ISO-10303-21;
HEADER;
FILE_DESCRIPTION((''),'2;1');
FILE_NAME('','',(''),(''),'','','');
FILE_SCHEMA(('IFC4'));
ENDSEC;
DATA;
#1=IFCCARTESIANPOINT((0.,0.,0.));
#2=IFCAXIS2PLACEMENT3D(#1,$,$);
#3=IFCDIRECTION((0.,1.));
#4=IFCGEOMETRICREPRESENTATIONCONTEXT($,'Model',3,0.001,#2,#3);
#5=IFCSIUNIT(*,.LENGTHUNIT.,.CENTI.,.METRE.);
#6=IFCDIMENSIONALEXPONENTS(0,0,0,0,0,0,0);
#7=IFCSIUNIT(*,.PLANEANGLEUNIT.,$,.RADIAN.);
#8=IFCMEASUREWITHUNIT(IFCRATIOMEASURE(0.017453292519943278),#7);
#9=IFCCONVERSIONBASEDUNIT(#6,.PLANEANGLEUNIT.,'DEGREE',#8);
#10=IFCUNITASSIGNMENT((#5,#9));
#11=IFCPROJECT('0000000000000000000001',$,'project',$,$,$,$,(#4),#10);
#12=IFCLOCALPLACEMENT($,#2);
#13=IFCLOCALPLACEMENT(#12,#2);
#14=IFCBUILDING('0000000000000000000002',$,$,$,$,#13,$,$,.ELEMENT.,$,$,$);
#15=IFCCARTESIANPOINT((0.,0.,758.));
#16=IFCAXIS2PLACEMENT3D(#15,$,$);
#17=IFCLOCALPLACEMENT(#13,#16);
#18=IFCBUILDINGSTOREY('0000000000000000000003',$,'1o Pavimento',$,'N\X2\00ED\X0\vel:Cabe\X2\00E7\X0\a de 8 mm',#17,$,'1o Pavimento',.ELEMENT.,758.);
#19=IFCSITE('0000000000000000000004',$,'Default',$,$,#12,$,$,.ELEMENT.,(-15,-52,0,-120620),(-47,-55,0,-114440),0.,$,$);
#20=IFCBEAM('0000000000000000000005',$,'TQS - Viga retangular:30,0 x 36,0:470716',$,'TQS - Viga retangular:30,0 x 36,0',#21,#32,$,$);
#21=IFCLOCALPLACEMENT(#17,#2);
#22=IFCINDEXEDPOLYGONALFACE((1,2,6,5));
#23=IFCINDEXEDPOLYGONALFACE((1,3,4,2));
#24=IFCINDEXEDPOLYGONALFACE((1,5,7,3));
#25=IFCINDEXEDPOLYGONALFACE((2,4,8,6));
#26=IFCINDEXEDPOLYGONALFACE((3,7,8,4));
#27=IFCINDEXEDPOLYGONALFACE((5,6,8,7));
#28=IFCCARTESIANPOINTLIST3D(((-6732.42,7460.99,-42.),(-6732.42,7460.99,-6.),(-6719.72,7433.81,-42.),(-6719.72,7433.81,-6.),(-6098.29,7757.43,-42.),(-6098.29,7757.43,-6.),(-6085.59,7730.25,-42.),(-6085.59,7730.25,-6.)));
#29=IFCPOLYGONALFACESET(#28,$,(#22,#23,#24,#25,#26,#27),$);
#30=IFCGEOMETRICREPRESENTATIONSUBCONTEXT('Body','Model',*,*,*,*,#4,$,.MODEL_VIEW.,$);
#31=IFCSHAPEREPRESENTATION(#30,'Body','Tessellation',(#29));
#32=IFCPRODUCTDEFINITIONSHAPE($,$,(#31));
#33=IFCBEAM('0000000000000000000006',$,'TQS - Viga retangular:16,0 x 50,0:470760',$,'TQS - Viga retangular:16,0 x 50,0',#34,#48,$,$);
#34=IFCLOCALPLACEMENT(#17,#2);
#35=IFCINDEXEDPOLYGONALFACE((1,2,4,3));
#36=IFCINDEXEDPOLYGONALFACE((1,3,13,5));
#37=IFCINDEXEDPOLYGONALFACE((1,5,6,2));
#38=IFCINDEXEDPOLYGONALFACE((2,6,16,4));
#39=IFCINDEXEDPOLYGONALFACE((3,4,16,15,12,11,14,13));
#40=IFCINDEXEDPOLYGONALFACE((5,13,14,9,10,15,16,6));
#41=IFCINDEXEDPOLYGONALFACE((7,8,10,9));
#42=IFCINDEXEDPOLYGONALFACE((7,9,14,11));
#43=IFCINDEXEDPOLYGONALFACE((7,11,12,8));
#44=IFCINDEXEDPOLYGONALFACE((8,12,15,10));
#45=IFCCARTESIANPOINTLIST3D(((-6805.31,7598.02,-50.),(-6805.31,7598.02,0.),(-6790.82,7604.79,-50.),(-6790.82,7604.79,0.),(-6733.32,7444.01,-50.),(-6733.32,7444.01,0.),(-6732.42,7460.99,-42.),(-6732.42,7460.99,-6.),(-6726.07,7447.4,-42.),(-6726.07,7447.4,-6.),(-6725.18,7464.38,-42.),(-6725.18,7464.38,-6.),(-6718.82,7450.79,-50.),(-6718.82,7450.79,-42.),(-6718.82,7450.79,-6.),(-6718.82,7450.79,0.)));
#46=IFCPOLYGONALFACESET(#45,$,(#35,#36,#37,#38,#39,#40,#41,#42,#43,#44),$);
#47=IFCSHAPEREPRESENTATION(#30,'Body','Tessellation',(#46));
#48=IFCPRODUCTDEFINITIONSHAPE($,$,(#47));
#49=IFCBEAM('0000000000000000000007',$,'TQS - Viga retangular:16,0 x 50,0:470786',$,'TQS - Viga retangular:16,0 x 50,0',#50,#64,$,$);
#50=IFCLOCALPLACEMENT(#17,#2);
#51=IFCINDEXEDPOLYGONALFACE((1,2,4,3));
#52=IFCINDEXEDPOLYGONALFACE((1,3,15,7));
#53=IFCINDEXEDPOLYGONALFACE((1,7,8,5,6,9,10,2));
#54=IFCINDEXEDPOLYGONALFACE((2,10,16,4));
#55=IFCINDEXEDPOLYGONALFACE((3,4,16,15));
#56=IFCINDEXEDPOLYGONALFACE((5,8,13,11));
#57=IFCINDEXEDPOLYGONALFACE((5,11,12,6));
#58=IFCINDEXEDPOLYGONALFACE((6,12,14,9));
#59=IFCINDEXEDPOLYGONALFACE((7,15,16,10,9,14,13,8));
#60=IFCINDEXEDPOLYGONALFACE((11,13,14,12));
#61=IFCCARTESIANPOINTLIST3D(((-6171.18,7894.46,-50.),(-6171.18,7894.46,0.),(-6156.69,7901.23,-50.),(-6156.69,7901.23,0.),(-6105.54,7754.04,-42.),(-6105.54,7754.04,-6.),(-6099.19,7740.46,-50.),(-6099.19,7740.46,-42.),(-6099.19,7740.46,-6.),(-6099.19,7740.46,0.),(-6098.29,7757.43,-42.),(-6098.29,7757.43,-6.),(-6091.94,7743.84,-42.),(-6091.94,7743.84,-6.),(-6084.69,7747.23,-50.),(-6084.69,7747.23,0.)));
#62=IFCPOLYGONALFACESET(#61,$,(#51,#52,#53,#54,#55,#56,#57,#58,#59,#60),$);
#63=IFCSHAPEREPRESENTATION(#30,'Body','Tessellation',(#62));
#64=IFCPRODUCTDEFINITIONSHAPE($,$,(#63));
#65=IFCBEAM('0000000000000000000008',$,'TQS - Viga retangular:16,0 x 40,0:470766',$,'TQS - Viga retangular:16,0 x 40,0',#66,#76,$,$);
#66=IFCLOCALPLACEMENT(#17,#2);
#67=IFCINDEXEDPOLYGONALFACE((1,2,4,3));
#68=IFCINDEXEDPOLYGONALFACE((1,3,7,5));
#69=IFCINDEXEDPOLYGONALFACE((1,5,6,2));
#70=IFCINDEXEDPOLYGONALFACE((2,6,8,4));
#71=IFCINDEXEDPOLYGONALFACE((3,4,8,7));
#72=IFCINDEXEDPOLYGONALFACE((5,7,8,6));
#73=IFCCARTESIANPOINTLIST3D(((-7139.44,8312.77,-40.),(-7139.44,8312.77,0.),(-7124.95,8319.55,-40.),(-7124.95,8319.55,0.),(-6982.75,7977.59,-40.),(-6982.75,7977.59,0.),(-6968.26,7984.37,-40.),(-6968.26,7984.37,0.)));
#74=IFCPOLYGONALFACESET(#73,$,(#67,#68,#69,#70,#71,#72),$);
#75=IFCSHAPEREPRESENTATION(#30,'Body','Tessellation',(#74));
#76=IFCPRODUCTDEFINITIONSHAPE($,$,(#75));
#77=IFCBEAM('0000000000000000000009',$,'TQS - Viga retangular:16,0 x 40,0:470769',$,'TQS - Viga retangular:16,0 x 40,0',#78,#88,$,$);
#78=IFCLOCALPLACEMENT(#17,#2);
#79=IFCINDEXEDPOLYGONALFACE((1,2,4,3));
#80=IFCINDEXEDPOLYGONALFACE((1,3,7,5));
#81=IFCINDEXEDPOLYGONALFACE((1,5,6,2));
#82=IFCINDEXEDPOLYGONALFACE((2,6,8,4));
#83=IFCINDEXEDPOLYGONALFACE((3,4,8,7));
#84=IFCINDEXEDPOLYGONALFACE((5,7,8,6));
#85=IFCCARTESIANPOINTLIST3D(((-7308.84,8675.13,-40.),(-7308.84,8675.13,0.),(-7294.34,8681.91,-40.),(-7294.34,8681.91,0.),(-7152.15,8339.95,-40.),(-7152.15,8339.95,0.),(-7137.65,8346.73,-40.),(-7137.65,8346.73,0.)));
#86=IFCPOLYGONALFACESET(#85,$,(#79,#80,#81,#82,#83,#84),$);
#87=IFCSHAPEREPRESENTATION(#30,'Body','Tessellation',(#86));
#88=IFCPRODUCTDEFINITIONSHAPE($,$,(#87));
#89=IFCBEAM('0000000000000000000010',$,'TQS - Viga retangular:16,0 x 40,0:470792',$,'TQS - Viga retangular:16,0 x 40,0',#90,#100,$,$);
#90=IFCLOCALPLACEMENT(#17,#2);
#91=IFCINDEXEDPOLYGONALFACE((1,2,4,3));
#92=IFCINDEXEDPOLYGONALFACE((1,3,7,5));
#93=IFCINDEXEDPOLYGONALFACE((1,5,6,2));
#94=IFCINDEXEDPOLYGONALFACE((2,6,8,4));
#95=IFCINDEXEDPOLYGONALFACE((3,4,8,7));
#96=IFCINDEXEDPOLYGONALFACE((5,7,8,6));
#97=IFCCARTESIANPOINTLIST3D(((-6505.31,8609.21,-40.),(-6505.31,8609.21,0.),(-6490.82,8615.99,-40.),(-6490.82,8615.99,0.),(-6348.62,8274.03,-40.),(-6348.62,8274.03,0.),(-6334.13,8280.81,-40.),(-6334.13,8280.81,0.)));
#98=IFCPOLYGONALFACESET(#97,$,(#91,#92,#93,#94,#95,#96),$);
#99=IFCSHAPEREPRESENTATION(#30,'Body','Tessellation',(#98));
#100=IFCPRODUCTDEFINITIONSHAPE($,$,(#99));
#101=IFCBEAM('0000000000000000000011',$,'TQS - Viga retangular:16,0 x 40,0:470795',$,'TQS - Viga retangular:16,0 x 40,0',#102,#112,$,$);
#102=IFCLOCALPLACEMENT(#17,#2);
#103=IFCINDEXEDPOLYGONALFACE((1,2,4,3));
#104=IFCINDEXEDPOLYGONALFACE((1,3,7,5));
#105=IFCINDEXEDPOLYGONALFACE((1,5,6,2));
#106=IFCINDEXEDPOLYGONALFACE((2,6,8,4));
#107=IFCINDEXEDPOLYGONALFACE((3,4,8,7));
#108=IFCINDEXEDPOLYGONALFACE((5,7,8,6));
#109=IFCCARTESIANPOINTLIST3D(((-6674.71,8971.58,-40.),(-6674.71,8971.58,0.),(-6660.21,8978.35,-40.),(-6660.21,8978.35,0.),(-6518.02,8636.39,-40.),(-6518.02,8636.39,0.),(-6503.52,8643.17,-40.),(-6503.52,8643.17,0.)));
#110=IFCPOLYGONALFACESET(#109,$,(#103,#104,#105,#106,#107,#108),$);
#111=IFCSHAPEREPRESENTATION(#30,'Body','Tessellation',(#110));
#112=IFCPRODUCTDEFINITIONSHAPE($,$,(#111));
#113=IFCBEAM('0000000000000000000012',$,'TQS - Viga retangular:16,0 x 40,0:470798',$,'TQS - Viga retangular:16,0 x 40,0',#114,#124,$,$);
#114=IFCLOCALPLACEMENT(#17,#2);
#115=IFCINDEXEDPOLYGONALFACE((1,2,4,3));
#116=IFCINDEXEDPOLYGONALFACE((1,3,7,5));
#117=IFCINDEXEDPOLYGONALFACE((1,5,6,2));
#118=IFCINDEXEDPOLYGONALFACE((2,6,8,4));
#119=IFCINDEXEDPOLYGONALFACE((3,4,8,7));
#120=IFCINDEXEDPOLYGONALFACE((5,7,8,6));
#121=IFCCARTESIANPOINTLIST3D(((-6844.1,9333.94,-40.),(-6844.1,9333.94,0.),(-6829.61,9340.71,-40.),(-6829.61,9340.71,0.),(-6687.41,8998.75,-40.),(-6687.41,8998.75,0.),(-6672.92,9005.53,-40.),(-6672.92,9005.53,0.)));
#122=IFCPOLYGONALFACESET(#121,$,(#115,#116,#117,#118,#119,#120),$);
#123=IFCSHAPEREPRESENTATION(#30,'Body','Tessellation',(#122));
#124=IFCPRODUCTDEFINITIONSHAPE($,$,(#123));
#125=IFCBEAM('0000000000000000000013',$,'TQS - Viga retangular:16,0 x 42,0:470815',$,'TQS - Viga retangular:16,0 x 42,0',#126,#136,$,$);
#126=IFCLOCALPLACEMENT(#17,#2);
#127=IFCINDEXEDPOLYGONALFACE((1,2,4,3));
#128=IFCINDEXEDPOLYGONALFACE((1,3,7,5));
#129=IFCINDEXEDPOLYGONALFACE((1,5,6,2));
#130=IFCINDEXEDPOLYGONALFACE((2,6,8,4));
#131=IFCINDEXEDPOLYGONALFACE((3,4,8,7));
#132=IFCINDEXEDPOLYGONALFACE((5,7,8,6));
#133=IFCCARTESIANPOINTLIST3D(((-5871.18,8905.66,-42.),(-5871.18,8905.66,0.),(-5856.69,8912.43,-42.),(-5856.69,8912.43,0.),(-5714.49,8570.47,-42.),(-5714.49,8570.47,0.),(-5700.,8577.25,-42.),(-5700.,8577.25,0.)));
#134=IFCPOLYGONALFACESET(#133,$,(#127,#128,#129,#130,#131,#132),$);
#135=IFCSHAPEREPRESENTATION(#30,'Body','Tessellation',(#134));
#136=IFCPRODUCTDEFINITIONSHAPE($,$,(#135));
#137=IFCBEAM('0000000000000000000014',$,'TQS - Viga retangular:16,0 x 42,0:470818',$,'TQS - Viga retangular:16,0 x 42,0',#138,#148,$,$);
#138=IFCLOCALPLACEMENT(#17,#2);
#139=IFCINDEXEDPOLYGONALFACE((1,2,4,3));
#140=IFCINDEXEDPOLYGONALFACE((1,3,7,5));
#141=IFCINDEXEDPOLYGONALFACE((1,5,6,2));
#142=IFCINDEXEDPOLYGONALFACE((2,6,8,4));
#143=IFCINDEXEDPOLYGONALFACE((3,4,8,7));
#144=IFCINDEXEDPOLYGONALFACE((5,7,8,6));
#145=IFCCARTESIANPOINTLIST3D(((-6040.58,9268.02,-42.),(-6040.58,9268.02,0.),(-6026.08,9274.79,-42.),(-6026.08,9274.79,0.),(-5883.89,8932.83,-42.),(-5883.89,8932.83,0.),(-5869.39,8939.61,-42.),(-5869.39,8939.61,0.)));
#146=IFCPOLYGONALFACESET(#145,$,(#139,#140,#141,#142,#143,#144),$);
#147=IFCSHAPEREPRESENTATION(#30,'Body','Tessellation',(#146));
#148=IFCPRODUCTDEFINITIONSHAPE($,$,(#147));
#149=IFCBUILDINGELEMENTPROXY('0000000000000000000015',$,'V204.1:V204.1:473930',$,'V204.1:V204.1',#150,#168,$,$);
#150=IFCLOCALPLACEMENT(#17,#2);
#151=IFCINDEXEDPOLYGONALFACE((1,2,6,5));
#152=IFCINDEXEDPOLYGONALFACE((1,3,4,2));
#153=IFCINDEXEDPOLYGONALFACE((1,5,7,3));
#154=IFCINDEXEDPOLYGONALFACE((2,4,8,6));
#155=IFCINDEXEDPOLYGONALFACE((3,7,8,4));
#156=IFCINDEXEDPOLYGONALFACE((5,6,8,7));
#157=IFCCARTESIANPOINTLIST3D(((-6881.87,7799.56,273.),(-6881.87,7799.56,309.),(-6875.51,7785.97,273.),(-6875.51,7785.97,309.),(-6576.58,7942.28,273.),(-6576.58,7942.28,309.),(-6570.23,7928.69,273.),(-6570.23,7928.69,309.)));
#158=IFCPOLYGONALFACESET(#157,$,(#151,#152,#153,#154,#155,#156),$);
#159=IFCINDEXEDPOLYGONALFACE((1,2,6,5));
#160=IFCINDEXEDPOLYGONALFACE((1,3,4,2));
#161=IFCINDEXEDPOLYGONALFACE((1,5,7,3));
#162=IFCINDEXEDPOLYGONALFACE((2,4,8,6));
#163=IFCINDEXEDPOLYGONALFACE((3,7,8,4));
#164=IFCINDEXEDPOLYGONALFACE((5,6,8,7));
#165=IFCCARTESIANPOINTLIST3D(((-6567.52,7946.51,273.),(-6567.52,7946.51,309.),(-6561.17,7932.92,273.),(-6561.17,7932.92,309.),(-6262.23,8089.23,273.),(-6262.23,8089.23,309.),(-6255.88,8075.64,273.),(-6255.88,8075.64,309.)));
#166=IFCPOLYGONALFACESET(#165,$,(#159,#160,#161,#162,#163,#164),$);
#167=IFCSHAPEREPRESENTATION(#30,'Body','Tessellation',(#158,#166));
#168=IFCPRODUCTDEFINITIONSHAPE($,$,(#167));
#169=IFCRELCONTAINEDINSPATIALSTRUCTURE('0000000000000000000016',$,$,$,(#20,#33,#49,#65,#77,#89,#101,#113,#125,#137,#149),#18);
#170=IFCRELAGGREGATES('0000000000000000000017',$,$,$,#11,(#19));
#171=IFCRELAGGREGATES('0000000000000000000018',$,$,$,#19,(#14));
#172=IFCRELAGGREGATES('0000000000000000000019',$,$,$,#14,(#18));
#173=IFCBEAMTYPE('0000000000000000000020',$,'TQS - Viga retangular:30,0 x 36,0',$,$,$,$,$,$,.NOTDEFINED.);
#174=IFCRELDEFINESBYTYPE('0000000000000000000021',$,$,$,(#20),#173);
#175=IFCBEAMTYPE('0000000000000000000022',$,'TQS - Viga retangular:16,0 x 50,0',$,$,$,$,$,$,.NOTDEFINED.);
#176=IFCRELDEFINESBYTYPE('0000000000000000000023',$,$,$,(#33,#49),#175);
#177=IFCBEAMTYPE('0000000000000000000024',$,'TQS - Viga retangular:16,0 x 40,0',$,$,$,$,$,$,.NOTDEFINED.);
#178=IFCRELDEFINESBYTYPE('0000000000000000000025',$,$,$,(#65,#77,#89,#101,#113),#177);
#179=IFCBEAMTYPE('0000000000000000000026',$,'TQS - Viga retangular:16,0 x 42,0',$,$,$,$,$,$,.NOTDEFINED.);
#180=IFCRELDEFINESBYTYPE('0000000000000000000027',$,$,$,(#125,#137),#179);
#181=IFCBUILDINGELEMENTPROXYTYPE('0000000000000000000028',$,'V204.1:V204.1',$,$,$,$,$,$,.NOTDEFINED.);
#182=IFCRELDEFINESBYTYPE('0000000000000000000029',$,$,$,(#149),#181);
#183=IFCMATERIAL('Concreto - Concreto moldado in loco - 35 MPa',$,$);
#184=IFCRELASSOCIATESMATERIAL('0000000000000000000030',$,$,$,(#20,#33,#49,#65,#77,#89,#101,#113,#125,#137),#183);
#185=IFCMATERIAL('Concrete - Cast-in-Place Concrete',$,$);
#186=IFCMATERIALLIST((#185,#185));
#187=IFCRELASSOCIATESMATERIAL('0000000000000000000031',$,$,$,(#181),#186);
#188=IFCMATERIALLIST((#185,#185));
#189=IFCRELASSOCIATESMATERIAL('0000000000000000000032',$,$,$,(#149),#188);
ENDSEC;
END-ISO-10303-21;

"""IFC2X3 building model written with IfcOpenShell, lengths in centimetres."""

from ifc_helpers import new_model, entity, si_unit, converted_unit, direction, frame, frame_2d, origin, origin_2d_with_axis, place, context, subcontext, project, spatial, polyline, rectangle, extrude, boolean, clip, bounded_halfspace, source, transform, mapped, material, material_list, type_object, type_shapes, element, save


model = new_model("IFC2X3")

# Units and contexts
model_context = context("Model", 3, precision=0.001, world=origin(), true_north=direction((0.0, 1.0)))
body_context = subcontext(model_context, "Body", "Model", "MODEL_VIEW")
ifc_project = project(units=[si_unit("LENGTHUNIT", "METRE", prefix="CENTI"), converted_unit("PLANEANGLEUNIT", "DEGREE", entity("IfcRatioMeasure", 0.017453292519943278), si_unit("PLANEANGLEUNIT", "RADIAN"), dimensions=[0, 0, 0, 0, 0, 0, 0])], contexts=[model_context])

# Site, building, storey
site_placement = place(None, origin())
site = spatial("IfcSite", under=ifc_project, at=site_placement, Name="Default", CompositionType="ELEMENT", RefLatitude=(-15, -52, 0, -120620), RefLongitude=(-47, -55, 0, -114440), RefElevation=0.0)
building_placement = place(site_placement, origin())
building = spatial("IfcBuilding", under=site, at=building_placement, CompositionType="ELEMENT")
storey_placement = place(building_placement, frame((0.0, 0.0, 758.0)))
storey = spatial("IfcBuildingStorey", under=building, at=storey_placement, Name="1o Pavimento", ObjectType="Nível:Cabeça de 8 mm", LongName="1o Pavimento", CompositionType="ELEMENT", Elevation=758.0)

# Beams
ifc_material_1 = material(Name="Concreto - Concreto moldado in loco - 35 MPa")
beam_type_1 = type_object("IfcBeamType", Name="TQS - Viga retangular:30,0 x 36,0", PredefinedType="NOTDEFINED")
beam_1_placement = place(storey_placement, frame((-6726.07, 7447.4, -6.0), z_axis=(0.0, 0.0, 1.0), x_axis=(0.905902, 0.423488, 0.0)))
element("IfcBeam", 1, at=beam_1_placement, inside=storey, type_object=beam_type_1, material=ifc_material_1, Name="TQS - Viga retangular:30,0 x 36,0:470716", ObjectType="TQS - Viga retangular:30,0 x 36,0", context=body_context, shape_type="SweptSolid", body=[
    extrude(rectangle(XDim=36.0, YDim=30.0, at=frame_2d((0.0, 0.0), x_axis=(1.0, 0.0))), frame((0.0, 0.0, -18.0), z_axis=(1.0, 0.0, 0.0), x_axis=(0.0, 0.0, -1.0)), (0.0, 0.0, 1.0), 700.0),
])
beam_type_2 = type_object("IfcBeamType", Name="TQS - Viga retangular:16,0 x 50,0", PredefinedType="NOTDEFINED")
beam_2_placement = place(storey_placement, frame((-6726.07, 7447.4, 0.0), z_axis=(0.0, 0.0, 1.0), x_axis=(-0.423488, 0.905902, 0.0)))
element("IfcBeam", 2, at=beam_2_placement, inside=storey, type_object=beam_type_2, material=ifc_material_1, Name="TQS - Viga retangular:16,0 x 50,0:470760", ObjectType="TQS - Viga retangular:16,0 x 50,0", context=body_context, shape_type="SweptSolid", body=[
    boolean("DIFFERENCE", clip(extrude(rectangle(XDim=50.0, YDim=16.0, at=frame_2d((0.0, 0.0), x_axis=(0.0, 1.0))), frame((0.0, 0.0, -25.0), z_axis=(1.0, 0.0, 0.0), x_axis=(0.0, 1.0, 0.0)), (0.0, 0.0, 1.0), 170.0), bounded_halfspace(frame((15.0, -700.0, -42.0), z_axis=(-1.0, 0.0, 0.0), x_axis=(0.0, 1.0, 0.0)), False, frame((0.0, 0.0, -25.0), z_axis=(1.0, 0.0, 0.0), x_axis=(0.0, 1.0, 0.0)), polyline([(0.0, 19.0), (0.0, -17.0), (-8.0, -17.0), (-8.0, 9.0), (-8.0, 19.0), (0.0, 19.0)]))), extrude(rectangle(XDim=36.0, YDim=8.0, at=frame_2d((0.0, 0.0), x_axis=(0.0, 1.0))), frame((15.0, -4.0, -24.0), z_axis=(1.0, 0.0, 0.0), x_axis=(0.0, 1.0, 0.0)), (0.0, 0.0, -1.0), 15.0)),
])
beam_3_placement = place(storey_placement, frame((-6091.94, 7743.84, 0.0), z_axis=(0.0, 0.0, 1.0), x_axis=(-0.423488, 0.905902, 0.0)))
element("IfcBeam", 3, at=beam_3_placement, inside=storey, type_object=beam_type_2, material=ifc_material_1, Name="TQS - Viga retangular:16,0 x 50,0:470786", ObjectType="TQS - Viga retangular:16,0 x 50,0", context=body_context, shape_type="SweptSolid", body=[
    boolean("DIFFERENCE", clip(extrude(rectangle(XDim=50.0, YDim=16.0, at=frame_2d((0.0, 0.0), x_axis=(1.0, 0.0))), frame((0.0, 0.0, -25.0), z_axis=(1.0, 0.0, 0.0), x_axis=(0.0, 0.0, -1.0)), (0.0, 0.0, 1.0), 170.0), bounded_halfspace(frame((15.0, 0.0, -42.0), z_axis=(-1.0, 0.0, 0.0), x_axis=(0.0, 1.0, 0.0)), False, frame((0.0, 0.0, -25.0), z_axis=(1.0, 0.0, 0.0), x_axis=(0.0, 0.0, -1.0)), polyline([(17.0, 0.0), (-19.0, 0.0), (-19.0, 8.0), (-9.0, 8.0), (17.0, 8.0), (17.0, 0.0)]))), extrude(rectangle(XDim=36.0, YDim=8.0, at=frame_2d((0.0, 0.0), x_axis=(0.0, 1.0))), frame((0.0, 4.0, -24.0), z_axis=(-1.0, 0.0, 0.0), x_axis=(0.0, -1.0, 0.0)), (0.0, 0.0, -1.0), 15.0)),
])
beam_type_3 = type_object("IfcBeamType", Name="TQS - Viga retangular:16,0 x 40,0", PredefinedType="NOTDEFINED")
beam_4_placement = place(storey_placement, frame((-6972.12, 7973.73, 0.0), z_axis=(0.0, 0.0, 1.0), x_axis=(-0.423488, 0.905902, 0.0)))
element("IfcBeam", 4, at=beam_4_placement, inside=storey, type_object=beam_type_3, material=ifc_material_1, Name="TQS - Viga retangular:16,0 x 40,0:470766", ObjectType="TQS - Viga retangular:16,0 x 40,0", context=body_context, shape_type="SweptSolid", body=[
    extrude(rectangle(XDim=40.0, YDim=16.0, at=origin_2d_with_axis()), frame((8.0, 0.0, -20.0), z_axis=(1.0, 0.0, 0.0), x_axis=(0.0, 0.0, -1.0)), (0.0, 0.0, 1.0), 370.0),
])
beam_5_placement = place(storey_placement, frame((-7141.51, 8336.09, 0.0), z_axis=(0.0, 0.0, 1.0), x_axis=(-0.423488, 0.905902, 0.0)))
element("IfcBeam", 5, at=beam_5_placement, inside=storey, type_object=beam_type_3, material=ifc_material_1, Name="TQS - Viga retangular:16,0 x 40,0:470769", ObjectType="TQS - Viga retangular:16,0 x 40,0", context=body_context, shape_type="SweptSolid", body=[
    extrude(rectangle(XDim=40.0, YDim=16.0, at=origin_2d_with_axis()), frame((8.0, 0.0, -20.0), z_axis=(1.0, 0.0, 0.0), x_axis=(0.0, 0.0, -1.0)), (0.0, 0.0, 1.0), 370.0),
])
beam_6_placement = place(storey_placement, frame((-6337.99, 8270.17, 0.0), z_axis=(0.0, 0.0, 1.0), x_axis=(-0.423488, 0.905902, 0.0)))
element("IfcBeam", 6, at=beam_6_placement, inside=storey, type_object=beam_type_3, material=ifc_material_1, Name="TQS - Viga retangular:16,0 x 40,0:470792", ObjectType="TQS - Viga retangular:16,0 x 40,0", context=body_context, shape_type="SweptSolid", body=[
    extrude(rectangle(XDim=40.0, YDim=16.0, at=frame_2d((0.0, 0.0), x_axis=(1.0, 0.0))), frame((8.0, 0.0, -20.0), z_axis=(1.0, 0.0, 0.0), x_axis=(0.0, 0.0, -1.0)), (0.0, 0.0, 1.0), 370.0),
])
beam_7_placement = place(storey_placement, frame((-6507.38, 8632.53, 0.0), z_axis=(0.0, 0.0, 1.0), x_axis=(-0.423488, 0.905902, 0.0)))
element("IfcBeam", 7, at=beam_7_placement, inside=storey, type_object=beam_type_3, material=ifc_material_1, Name="TQS - Viga retangular:16,0 x 40,0:470795", ObjectType="TQS - Viga retangular:16,0 x 40,0", context=body_context, shape_type="SweptSolid", body=[
    extrude(rectangle(XDim=40.0, YDim=16.0, at=origin_2d_with_axis()), frame((8.0, 0.0, -20.0), z_axis=(1.0, 0.0, 0.0), x_axis=(0.0, 0.0, -1.0)), (0.0, 0.0, 1.0), 370.0),
])
beam_8_placement = place(storey_placement, frame((-6676.78, 8994.89, 0.0), z_axis=(0.0, 0.0, 1.0), x_axis=(-0.423488, 0.905902, 0.0)))
element("IfcBeam", 8, at=beam_8_placement, inside=storey, type_object=beam_type_3, material=ifc_material_1, Name="TQS - Viga retangular:16,0 x 40,0:470798", ObjectType="TQS - Viga retangular:16,0 x 40,0", context=body_context, shape_type="SweptSolid", body=[
    extrude(rectangle(XDim=40.0, YDim=16.0, at=frame_2d((0.0, 0.0), x_axis=(1.0, 0.0))), frame((8.0, 0.0, -20.0), z_axis=(1.0, 0.0, 0.0), x_axis=(0.0, 0.0, -1.0)), (0.0, 0.0, 1.0), 370.0),
])
beam_type_4 = type_object("IfcBeamType", Name="TQS - Viga retangular:16,0 x 42,0", PredefinedType="NOTDEFINED")
beam_9_placement = place(storey_placement, frame((-5703.85, 8566.61, 0.0), z_axis=(0.0, 0.0, 1.0), x_axis=(-0.423488, 0.905902, 0.0)))
element("IfcBeam", 9, at=beam_9_placement, inside=storey, type_object=beam_type_4, material=ifc_material_1, Name="TQS - Viga retangular:16,0 x 42,0:470815", ObjectType="TQS - Viga retangular:16,0 x 42,0", context=body_context, shape_type="SweptSolid", body=[
    extrude(rectangle(XDim=42.0, YDim=16.0, at=origin_2d_with_axis()), frame((8.0, 0.0, -21.0), z_axis=(1.0, 0.0, 0.0), x_axis=(0.0, 0.0, -1.0)), (0.0, 0.0, 1.0), 370.0),
])
beam_10_placement = place(storey_placement, frame((-5873.25, 8928.97, 0.0), z_axis=(0.0, 0.0, 1.0), x_axis=(-0.423488, 0.905902, 0.0)))
element("IfcBeam", 10, at=beam_10_placement, inside=storey, type_object=beam_type_4, material=ifc_material_1, Name="TQS - Viga retangular:16,0 x 42,0:470818", ObjectType="TQS - Viga retangular:16,0 x 42,0", context=body_context, shape_type="SweptSolid", body=[
    extrude(rectangle(XDim=42.0, YDim=16.0, at=origin_2d_with_axis()), frame((8.0, 0.0, -21.0), z_axis=(1.0, 0.0, 0.0), x_axis=(0.0, 0.0, -1.0)), (0.0, 0.0, 1.0), 370.0),
])

# Building element proxy
ifc_material_2 = material(Name="Concrete - Cast-in-Place Concrete")
ifc_material_list_1 = material_list([ifc_material_2, ifc_material_2])
ifc_material_list_2 = material_list([ifc_material_2, ifc_material_2])
building_element_proxy_type_1 = type_object("IfcBuildingElementProxyType", Name="V204.1:V204.1", PredefinedType="NOTDEFINED", material=ifc_material_list_2)
shared_shape_1 = source(origin(), body_context, "Body", "SweptSolid", [
    extrude(rectangle(XDim=15.0, YDim=337.0, at=frame_2d((0.0, 0.0), x_axis=(1.0, 0.0))), frame((155.82, 78.15, 0.0), z_axis=(0.0, 0.0, 1.0), x_axis=(-0.423488, 0.905902, 0.0)), (0.0, 0.0, 1.0), 36.0),
    extrude(rectangle(XDim=337.0, YDim=15.0, at=origin_2d_with_axis()), frame((470.17, 225.1, 0.0), z_axis=(0.0, 0.0, 1.0), x_axis=(-0.905902, -0.423488, 0.0)), (0.0, 0.0, 1.0), 36.0),
])
type_shapes(building_element_proxy_type_1, [shared_shape_1])
proxy_1_placement = place(storey_placement, frame((-6881.87, 7785.97, 273.0)))
element("IfcBuildingElementProxy", 11, at=proxy_1_placement, inside=storey, type_object=building_element_proxy_type_1, material=ifc_material_list_1, Name="V204.1:V204.1:473930", ObjectType="V204.1:V204.1", context=body_context, shape_type="MappedRepresentation", body=[
    mapped(shared_shape_1, transform((0.0, 0.0, 0.0), scale=1.0)),
])

save(model, "model.ifc")
